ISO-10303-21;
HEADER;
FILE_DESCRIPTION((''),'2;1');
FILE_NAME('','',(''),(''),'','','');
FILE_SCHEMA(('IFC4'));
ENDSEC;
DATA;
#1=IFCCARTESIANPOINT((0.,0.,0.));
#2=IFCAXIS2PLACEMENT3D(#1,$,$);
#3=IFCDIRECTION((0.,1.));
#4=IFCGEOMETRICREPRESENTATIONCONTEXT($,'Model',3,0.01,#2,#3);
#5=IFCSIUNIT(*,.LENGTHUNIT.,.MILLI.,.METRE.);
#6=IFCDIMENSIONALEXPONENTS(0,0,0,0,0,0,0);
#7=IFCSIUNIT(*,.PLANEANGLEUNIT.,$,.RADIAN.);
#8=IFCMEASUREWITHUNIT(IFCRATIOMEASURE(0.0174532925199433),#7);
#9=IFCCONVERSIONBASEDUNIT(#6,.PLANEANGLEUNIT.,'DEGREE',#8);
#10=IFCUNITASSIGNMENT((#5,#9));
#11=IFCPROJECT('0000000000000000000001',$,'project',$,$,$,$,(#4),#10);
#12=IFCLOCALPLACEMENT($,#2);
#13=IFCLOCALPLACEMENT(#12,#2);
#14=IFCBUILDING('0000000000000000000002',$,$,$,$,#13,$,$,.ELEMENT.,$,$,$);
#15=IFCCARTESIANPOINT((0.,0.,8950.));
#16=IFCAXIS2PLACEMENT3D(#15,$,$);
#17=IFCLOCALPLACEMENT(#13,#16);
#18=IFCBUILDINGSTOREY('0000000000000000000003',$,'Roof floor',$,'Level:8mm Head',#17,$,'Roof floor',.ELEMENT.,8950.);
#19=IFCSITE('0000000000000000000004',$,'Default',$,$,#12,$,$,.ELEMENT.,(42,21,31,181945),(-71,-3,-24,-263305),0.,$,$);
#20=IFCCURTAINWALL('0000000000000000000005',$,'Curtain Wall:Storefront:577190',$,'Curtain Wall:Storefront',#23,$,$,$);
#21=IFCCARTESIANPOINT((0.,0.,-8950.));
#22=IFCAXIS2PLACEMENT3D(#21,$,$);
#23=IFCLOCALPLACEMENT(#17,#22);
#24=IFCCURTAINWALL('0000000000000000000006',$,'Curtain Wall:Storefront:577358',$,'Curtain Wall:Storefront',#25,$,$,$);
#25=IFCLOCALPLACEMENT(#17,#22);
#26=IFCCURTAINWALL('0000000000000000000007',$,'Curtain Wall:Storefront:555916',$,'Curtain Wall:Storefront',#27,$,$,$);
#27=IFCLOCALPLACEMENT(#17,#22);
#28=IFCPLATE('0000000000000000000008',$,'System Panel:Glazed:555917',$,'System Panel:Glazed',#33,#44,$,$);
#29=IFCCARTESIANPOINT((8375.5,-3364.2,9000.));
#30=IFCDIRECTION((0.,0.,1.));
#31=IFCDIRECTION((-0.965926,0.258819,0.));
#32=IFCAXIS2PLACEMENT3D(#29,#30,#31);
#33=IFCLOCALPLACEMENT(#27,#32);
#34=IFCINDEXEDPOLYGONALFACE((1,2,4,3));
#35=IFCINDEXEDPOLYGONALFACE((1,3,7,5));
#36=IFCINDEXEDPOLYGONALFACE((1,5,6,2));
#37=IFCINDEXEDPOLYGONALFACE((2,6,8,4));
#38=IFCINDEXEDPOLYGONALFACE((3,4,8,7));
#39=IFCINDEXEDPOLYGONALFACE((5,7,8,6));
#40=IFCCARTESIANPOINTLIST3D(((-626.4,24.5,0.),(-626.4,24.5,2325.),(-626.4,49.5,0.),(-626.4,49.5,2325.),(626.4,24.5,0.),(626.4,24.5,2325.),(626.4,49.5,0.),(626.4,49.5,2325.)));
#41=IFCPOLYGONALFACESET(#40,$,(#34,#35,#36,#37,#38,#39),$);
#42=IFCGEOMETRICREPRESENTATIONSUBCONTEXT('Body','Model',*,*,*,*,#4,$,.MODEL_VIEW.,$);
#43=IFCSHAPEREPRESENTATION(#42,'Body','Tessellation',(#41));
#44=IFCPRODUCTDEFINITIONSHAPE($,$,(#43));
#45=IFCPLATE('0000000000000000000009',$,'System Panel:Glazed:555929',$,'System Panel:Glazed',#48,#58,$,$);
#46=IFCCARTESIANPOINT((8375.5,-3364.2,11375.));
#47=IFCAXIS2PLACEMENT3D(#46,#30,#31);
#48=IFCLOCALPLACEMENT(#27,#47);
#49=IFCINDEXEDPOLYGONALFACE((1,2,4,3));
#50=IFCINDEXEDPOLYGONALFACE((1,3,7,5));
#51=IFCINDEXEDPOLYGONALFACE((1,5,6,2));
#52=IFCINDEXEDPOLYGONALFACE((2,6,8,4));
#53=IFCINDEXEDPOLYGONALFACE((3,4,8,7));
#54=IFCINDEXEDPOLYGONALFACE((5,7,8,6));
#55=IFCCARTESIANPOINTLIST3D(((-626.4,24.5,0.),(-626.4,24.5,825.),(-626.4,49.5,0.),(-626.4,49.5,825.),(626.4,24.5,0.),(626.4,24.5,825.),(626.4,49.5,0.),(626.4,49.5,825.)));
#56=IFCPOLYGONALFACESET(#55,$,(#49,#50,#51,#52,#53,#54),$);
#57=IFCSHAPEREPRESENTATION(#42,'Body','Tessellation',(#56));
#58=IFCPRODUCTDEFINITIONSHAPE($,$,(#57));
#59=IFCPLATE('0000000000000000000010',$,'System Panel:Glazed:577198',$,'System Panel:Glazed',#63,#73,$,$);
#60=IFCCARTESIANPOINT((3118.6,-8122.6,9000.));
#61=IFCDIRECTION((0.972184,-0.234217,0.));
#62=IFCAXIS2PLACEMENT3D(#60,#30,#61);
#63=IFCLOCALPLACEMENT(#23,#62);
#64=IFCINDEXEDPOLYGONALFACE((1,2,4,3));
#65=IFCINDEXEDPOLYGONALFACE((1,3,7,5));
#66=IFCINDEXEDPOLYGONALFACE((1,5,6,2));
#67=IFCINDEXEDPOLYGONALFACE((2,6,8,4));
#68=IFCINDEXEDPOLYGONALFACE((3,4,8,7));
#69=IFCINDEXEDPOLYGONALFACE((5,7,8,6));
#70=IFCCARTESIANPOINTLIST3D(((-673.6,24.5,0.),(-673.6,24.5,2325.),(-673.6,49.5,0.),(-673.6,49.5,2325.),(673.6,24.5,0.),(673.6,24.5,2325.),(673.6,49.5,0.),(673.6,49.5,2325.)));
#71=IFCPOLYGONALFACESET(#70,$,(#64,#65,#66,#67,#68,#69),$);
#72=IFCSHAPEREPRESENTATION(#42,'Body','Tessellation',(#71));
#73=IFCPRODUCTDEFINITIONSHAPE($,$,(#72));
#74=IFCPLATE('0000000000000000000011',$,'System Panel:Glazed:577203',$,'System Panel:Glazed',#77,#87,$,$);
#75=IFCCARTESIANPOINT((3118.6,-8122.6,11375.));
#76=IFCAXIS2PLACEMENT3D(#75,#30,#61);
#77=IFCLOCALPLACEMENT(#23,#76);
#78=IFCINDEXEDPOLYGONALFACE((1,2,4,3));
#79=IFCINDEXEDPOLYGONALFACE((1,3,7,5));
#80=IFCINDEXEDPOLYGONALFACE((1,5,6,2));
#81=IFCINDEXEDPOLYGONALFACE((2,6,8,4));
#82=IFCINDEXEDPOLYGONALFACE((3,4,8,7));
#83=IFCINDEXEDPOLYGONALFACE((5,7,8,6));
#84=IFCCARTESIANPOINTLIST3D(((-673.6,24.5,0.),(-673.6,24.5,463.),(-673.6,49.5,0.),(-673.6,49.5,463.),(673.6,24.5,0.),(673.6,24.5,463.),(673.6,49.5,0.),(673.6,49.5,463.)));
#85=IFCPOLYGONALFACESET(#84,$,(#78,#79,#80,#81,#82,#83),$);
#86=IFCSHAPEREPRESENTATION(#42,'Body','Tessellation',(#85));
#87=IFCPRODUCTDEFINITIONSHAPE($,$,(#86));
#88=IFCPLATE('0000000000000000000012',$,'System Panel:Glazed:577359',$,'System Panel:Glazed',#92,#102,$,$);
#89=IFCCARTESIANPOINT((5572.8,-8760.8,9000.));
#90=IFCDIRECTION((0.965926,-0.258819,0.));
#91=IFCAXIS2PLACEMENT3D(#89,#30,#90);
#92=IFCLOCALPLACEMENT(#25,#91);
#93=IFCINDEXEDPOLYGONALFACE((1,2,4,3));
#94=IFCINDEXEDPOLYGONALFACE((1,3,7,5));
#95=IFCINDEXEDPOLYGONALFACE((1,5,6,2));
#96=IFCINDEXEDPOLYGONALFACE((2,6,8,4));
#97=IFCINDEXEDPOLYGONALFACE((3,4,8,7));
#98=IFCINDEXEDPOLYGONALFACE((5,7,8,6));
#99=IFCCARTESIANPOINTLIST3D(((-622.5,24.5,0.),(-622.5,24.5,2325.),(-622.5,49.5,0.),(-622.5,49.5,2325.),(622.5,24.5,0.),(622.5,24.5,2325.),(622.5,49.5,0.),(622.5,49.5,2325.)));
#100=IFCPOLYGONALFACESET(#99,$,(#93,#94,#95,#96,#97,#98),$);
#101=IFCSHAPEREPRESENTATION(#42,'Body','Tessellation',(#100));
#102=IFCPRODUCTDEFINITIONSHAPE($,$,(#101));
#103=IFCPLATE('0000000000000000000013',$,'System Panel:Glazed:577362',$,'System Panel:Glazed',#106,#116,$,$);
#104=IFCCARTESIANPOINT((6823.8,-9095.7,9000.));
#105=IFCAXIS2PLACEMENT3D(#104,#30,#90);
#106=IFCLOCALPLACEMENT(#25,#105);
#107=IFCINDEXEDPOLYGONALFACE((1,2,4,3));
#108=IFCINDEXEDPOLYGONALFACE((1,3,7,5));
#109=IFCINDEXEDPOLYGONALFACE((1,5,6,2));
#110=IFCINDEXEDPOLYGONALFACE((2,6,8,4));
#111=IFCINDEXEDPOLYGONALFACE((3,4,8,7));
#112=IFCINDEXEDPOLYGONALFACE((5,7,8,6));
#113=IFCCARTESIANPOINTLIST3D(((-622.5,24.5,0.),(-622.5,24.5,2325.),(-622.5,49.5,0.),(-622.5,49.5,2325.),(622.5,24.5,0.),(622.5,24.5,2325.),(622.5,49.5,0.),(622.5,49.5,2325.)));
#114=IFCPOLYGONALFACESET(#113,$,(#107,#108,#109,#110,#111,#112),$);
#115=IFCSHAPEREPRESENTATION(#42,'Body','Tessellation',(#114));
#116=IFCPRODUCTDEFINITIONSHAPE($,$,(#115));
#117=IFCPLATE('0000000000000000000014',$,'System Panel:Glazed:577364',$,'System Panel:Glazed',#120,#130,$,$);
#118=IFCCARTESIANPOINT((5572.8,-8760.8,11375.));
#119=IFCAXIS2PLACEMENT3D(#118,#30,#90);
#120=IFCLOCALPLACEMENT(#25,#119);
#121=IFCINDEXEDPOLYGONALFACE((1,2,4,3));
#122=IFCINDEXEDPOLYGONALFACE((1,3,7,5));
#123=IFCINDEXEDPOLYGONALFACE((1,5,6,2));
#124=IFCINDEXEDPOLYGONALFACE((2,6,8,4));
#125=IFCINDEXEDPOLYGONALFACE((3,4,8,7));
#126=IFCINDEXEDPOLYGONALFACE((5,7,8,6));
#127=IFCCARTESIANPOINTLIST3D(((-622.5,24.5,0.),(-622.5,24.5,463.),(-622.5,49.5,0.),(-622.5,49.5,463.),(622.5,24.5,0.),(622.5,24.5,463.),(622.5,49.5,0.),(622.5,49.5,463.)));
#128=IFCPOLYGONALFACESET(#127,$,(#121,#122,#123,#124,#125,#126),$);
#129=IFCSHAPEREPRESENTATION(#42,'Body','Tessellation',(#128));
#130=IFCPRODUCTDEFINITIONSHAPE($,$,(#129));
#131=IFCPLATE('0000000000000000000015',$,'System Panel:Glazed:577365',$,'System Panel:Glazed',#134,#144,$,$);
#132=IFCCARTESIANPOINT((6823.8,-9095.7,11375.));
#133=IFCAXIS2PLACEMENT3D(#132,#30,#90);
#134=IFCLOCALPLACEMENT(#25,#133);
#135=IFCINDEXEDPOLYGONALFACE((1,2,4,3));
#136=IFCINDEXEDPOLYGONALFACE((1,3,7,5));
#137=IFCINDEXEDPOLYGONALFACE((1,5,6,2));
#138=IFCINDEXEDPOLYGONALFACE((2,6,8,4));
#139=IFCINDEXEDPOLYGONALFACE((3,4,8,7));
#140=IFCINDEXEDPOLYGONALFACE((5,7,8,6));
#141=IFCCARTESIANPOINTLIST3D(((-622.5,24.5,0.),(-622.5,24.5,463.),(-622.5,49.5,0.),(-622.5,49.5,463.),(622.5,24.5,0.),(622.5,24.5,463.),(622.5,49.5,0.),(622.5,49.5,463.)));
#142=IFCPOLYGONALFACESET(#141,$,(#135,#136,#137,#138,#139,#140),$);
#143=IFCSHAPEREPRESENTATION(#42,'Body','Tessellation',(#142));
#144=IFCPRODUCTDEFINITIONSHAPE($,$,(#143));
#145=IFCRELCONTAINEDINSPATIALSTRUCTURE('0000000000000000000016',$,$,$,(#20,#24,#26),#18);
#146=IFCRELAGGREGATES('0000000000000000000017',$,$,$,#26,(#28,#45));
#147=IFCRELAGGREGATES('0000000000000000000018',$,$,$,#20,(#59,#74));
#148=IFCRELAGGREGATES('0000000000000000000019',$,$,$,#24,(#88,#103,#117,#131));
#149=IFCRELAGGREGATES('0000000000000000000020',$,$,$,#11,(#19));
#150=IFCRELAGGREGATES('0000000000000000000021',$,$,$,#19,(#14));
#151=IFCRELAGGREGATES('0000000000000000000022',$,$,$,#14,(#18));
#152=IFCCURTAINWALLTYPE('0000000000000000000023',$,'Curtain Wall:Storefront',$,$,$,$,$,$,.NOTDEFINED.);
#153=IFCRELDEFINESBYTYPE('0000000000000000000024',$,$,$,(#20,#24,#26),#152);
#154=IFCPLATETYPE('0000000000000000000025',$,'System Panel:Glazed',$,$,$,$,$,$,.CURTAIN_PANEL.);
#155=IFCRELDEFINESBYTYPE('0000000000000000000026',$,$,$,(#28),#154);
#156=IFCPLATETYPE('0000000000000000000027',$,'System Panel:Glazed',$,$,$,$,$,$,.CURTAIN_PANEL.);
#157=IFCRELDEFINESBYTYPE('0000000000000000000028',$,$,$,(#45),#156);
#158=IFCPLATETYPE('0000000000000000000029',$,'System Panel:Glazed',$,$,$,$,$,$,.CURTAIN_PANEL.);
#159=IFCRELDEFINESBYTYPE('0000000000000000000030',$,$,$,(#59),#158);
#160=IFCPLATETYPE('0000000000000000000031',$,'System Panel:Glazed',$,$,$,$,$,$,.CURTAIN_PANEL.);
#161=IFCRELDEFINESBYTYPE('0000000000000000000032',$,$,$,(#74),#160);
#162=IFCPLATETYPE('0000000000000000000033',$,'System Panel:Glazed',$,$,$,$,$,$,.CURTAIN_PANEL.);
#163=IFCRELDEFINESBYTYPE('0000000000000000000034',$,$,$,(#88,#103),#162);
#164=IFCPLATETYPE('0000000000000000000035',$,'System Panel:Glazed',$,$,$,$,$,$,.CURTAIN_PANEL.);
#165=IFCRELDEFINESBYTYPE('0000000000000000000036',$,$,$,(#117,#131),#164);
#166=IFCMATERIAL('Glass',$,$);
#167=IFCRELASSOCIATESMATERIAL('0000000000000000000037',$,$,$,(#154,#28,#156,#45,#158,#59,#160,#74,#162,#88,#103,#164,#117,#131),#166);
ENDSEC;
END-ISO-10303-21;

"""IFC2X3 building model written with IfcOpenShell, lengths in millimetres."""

from ifc_helpers import new_model, entity, si_unit, converted_unit, direction, frame, frame_2d, origin, origin_2d_with_axis, place, context, subcontext, project, spatial, rectangle, extrude, source, transform, mapped, material, type_object, type_shapes, element, aggregate, save


model = new_model("IFC2X3")

# Units and contexts
model_context = context("Model", 3, precision=0.01, world=origin(), true_north=direction((0.0, 1.0)))
body_context = subcontext(model_context, "Body", "Model", "MODEL_VIEW")
ifc_project = project(units=[si_unit("LENGTHUNIT", "METRE", prefix="MILLI"), converted_unit("PLANEANGLEUNIT", "DEGREE", entity("IfcRatioMeasure", 0.0174532925199433), si_unit("PLANEANGLEUNIT", "RADIAN"), dimensions=[0, 0, 0, 0, 0, 0, 0])], contexts=[model_context])

# Site, building, storey
site_placement = place(None, origin())
site = spatial("IfcSite", under=ifc_project, at=site_placement, Name="Default", CompositionType="ELEMENT", RefLatitude=(42, 21, 31, 181945), RefLongitude=(-71, -3, -24, -263305), RefElevation=0.0)
building_placement = place(site_placement, origin())
building = spatial("IfcBuilding", under=site, at=building_placement, CompositionType="ELEMENT")
storey_placement = place(building_placement, frame((0.0, 0.0, 8950.0)))
storey = spatial("IfcBuildingStorey", under=building, at=storey_placement, Name="Roof floor", ObjectType="Level:8mm Head", LongName="Roof floor", CompositionType="ELEMENT", Elevation=8950.0)

# Curtain walls
curtain_wall_type = type_object("IfcCurtainWallType", Name="Curtain Wall:Storefront", PredefinedType="NOTDEFINED")
curtain_wall_1_placement = place(storey_placement, frame((0.0, 0.0, -8950.0)))
curtain_wall_1 = element("IfcCurtainWall", 1, at=curtain_wall_1_placement, inside=storey, type_object=curtain_wall_type, Name="Curtain Wall:Storefront:577190", ObjectType="Curtain Wall:Storefront")
curtain_wall_2_placement = place(storey_placement, frame((0.0, 0.0, -8950.0)))
curtain_wall_2 = element("IfcCurtainWall", 2, at=curtain_wall_2_placement, inside=storey, type_object=curtain_wall_type, Name="Curtain Wall:Storefront:577358", ObjectType="Curtain Wall:Storefront")
curtain_wall_3_placement = place(storey_placement, frame((0.0, 0.0, -8950.0)))
curtain_wall_3 = element("IfcCurtainWall", 3, at=curtain_wall_3_placement, inside=storey, type_object=curtain_wall_type, Name="Curtain Wall:Storefront:555916", ObjectType="Curtain Wall:Storefront")

# Plates
ifc_material_1 = material(Name="Glass")
plate_type_1 = type_object("IfcPlateType", Name="System Panel:Glazed", PredefinedType="CURTAIN_PANEL", material=ifc_material_1)
shared_shape_1 = source(origin(), body_context, "Body", "SweptSolid", [
    extrude(rectangle(XDim=25.0, YDim=1252.9, at=origin_2d_with_axis()), frame((0.0, 37.0, 0.0), z_axis=(0.0, 0.0, 1.0), x_axis=(0.0, 1.0, 0.0)), (0.0, 0.0, 1.0), 2325.0),
])
type_shapes(plate_type_1, [shared_shape_1])
plate_1_placement = place(curtain_wall_3_placement, frame((8375.5, -3364.2, 9000.0), z_axis=(0.0, 0.0, 1.0), x_axis=(-0.965926, 0.258819, 0.0)))
plate_1 = element("IfcPlate", 4, at=plate_1_placement, type_object=plate_type_1, material=ifc_material_1, Name="System Panel:Glazed:555917", ObjectType="System Panel:Glazed", context=body_context, shape_type="MappedRepresentation", body=[
    mapped(shared_shape_1, transform((0.0, 0.0, 0.0), scale=1.0)),
])
plate_type_2 = type_object("IfcPlateType", Name="System Panel:Glazed", PredefinedType="CURTAIN_PANEL", material=ifc_material_1)
shared_shape_2 = source(origin(), body_context, "Body", "SweptSolid", [
    extrude(rectangle(XDim=25.0, YDim=1252.9, at=origin_2d_with_axis()), frame((0.0, 37.0, 0.0), z_axis=(0.0, 0.0, 1.0), x_axis=(0.0, 1.0, 0.0)), (0.0, 0.0, 1.0), 825.0),
])
type_shapes(plate_type_2, [shared_shape_2])
plate_2_placement = place(curtain_wall_3_placement, frame((8375.5, -3364.2, 11375.0), z_axis=(0.0, 0.0, 1.0), x_axis=(-0.965926, 0.258819, 0.0)))
plate_2 = element("IfcPlate", 5, at=plate_2_placement, type_object=plate_type_2, material=ifc_material_1, Name="System Panel:Glazed:555929", ObjectType="System Panel:Glazed", context=body_context, shape_type="MappedRepresentation", body=[
    mapped(shared_shape_2, transform((0.0, 0.0, 0.0), scale=1.0)),
])
aggregate(curtain_wall_3, [plate_1, plate_2])
plate_type_3 = type_object("IfcPlateType", Name="System Panel:Glazed", PredefinedType="CURTAIN_PANEL", material=ifc_material_1)
shared_shape_3 = source(origin(), body_context, "Body", "SweptSolid", [
    extrude(rectangle(XDim=25.0, YDim=1347.1, at=origin_2d_with_axis()), frame((0.0, 37.0, 0.0), z_axis=(0.0, 0.0, 1.0), x_axis=(0.0, 1.0, 0.0)), (0.0, 0.0, 1.0), 2325.0),
])
type_shapes(plate_type_3, [shared_shape_3])
plate_3_placement = place(curtain_wall_1_placement, frame((3118.6, -8122.6, 9000.0), z_axis=(0.0, 0.0, 1.0), x_axis=(0.972184, -0.234217, 0.0)))
plate_3 = element("IfcPlate", 6, at=plate_3_placement, type_object=plate_type_3, material=ifc_material_1, Name="System Panel:Glazed:577198", ObjectType="System Panel:Glazed", context=body_context, shape_type="MappedRepresentation", body=[
    mapped(shared_shape_3, transform((0.0, 0.0, 0.0), scale=1.0)),
])
plate_type_4 = type_object("IfcPlateType", Name="System Panel:Glazed", PredefinedType="CURTAIN_PANEL", material=ifc_material_1)
shared_shape_4 = source(origin(), body_context, "Body", "SweptSolid", [
    extrude(rectangle(XDim=25.0, YDim=1347.1, at=origin_2d_with_axis()), frame((0.0, 37.0, 0.0), z_axis=(0.0, 0.0, 1.0), x_axis=(0.0, 1.0, 0.0)), (0.0, 0.0, 1.0), 463.0),
])
type_shapes(plate_type_4, [shared_shape_4])
plate_4_placement = place(curtain_wall_1_placement, frame((3118.6, -8122.6, 11375.0), z_axis=(0.0, 0.0, 1.0), x_axis=(0.972184, -0.234217, 0.0)))
plate_4 = element("IfcPlate", 7, at=plate_4_placement, type_object=plate_type_4, material=ifc_material_1, Name="System Panel:Glazed:577203", ObjectType="System Panel:Glazed", context=body_context, shape_type="MappedRepresentation", body=[
    mapped(shared_shape_4, transform((0.0, 0.0, 0.0), scale=1.0)),
])
aggregate(curtain_wall_1, [plate_3, plate_4])
plate_type_5 = type_object("IfcPlateType", Name="System Panel:Glazed", PredefinedType="CURTAIN_PANEL", material=ifc_material_1)
shared_shape_5 = source(origin(), body_context, "Body", "SweptSolid", [
    extrude(rectangle(XDim=25.0, YDim=1245.0, at=frame_2d((0.0, 0.0), x_axis=(1.0, 0.0))), frame((0.0, 37.0, 0.0), z_axis=(0.0, 0.0, 1.0), x_axis=(0.0, 1.0, 0.0)), (0.0, 0.0, 1.0), 2325.0),
])
type_shapes(plate_type_5, [shared_shape_5])
plate_5_placement = place(curtain_wall_2_placement, frame((5572.8, -8760.8, 9000.0), z_axis=(0.0, 0.0, 1.0), x_axis=(0.965926, -0.258819, 0.0)))
plate_5 = element("IfcPlate", 8, at=plate_5_placement, type_object=plate_type_5, material=ifc_material_1, Name="System Panel:Glazed:577359", ObjectType="System Panel:Glazed", context=body_context, shape_type="MappedRepresentation", body=[
    mapped(shared_shape_5, transform((0.0, 0.0, 0.0), scale=1.0)),
])
plate_6_placement = place(curtain_wall_2_placement, frame((6823.8, -9095.7, 9000.0), z_axis=(0.0, 0.0, 1.0), x_axis=(0.965926, -0.258819, 0.0)))
plate_6 = element("IfcPlate", 9, at=plate_6_placement, type_object=plate_type_5, material=ifc_material_1, Name="System Panel:Glazed:577362", ObjectType="System Panel:Glazed", context=body_context, shape_type="MappedRepresentation", body=[
    mapped(shared_shape_5, transform((0.0, 0.0, 0.0), scale=1.0)),
])
plate_type_6 = type_object("IfcPlateType", Name="System Panel:Glazed", PredefinedType="CURTAIN_PANEL", material=ifc_material_1)
shared_shape_6 = source(origin(), body_context, "Body", "SweptSolid", [
    extrude(rectangle(XDim=25.0, YDim=1245.0, at=frame_2d((0.0, 0.0), x_axis=(1.0, 0.0))), frame((0.0, 37.0, 0.0), z_axis=(0.0, 0.0, 1.0), x_axis=(0.0, 1.0, 0.0)), (0.0, 0.0, 1.0), 463.0),
])
type_shapes(plate_type_6, [shared_shape_6])
plate_7_placement = place(curtain_wall_2_placement, frame((5572.8, -8760.8, 11375.0), z_axis=(0.0, 0.0, 1.0), x_axis=(0.965926, -0.258819, 0.0)))
plate_7 = element("IfcPlate", 10, at=plate_7_placement, type_object=plate_type_6, material=ifc_material_1, Name="System Panel:Glazed:577364", ObjectType="System Panel:Glazed", context=body_context, shape_type="MappedRepresentation", body=[
    mapped(shared_shape_6, transform((0.0, 0.0, 0.0), scale=1.0)),
])
plate_8_placement = place(curtain_wall_2_placement, frame((6823.8, -9095.7, 11375.0), z_axis=(0.0, 0.0, 1.0), x_axis=(0.965926, -0.258819, 0.0)))
plate_8 = element("IfcPlate", 11, at=plate_8_placement, type_object=plate_type_6, material=ifc_material_1, Name="System Panel:Glazed:577365", ObjectType="System Panel:Glazed", context=body_context, shape_type="MappedRepresentation", body=[
    mapped(shared_shape_6, transform((0.0, 0.0, 0.0), scale=1.0)),
])
aggregate(curtain_wall_2, [plate_5, plate_6, plate_7, plate_8])

save(model, "model.ifc")
